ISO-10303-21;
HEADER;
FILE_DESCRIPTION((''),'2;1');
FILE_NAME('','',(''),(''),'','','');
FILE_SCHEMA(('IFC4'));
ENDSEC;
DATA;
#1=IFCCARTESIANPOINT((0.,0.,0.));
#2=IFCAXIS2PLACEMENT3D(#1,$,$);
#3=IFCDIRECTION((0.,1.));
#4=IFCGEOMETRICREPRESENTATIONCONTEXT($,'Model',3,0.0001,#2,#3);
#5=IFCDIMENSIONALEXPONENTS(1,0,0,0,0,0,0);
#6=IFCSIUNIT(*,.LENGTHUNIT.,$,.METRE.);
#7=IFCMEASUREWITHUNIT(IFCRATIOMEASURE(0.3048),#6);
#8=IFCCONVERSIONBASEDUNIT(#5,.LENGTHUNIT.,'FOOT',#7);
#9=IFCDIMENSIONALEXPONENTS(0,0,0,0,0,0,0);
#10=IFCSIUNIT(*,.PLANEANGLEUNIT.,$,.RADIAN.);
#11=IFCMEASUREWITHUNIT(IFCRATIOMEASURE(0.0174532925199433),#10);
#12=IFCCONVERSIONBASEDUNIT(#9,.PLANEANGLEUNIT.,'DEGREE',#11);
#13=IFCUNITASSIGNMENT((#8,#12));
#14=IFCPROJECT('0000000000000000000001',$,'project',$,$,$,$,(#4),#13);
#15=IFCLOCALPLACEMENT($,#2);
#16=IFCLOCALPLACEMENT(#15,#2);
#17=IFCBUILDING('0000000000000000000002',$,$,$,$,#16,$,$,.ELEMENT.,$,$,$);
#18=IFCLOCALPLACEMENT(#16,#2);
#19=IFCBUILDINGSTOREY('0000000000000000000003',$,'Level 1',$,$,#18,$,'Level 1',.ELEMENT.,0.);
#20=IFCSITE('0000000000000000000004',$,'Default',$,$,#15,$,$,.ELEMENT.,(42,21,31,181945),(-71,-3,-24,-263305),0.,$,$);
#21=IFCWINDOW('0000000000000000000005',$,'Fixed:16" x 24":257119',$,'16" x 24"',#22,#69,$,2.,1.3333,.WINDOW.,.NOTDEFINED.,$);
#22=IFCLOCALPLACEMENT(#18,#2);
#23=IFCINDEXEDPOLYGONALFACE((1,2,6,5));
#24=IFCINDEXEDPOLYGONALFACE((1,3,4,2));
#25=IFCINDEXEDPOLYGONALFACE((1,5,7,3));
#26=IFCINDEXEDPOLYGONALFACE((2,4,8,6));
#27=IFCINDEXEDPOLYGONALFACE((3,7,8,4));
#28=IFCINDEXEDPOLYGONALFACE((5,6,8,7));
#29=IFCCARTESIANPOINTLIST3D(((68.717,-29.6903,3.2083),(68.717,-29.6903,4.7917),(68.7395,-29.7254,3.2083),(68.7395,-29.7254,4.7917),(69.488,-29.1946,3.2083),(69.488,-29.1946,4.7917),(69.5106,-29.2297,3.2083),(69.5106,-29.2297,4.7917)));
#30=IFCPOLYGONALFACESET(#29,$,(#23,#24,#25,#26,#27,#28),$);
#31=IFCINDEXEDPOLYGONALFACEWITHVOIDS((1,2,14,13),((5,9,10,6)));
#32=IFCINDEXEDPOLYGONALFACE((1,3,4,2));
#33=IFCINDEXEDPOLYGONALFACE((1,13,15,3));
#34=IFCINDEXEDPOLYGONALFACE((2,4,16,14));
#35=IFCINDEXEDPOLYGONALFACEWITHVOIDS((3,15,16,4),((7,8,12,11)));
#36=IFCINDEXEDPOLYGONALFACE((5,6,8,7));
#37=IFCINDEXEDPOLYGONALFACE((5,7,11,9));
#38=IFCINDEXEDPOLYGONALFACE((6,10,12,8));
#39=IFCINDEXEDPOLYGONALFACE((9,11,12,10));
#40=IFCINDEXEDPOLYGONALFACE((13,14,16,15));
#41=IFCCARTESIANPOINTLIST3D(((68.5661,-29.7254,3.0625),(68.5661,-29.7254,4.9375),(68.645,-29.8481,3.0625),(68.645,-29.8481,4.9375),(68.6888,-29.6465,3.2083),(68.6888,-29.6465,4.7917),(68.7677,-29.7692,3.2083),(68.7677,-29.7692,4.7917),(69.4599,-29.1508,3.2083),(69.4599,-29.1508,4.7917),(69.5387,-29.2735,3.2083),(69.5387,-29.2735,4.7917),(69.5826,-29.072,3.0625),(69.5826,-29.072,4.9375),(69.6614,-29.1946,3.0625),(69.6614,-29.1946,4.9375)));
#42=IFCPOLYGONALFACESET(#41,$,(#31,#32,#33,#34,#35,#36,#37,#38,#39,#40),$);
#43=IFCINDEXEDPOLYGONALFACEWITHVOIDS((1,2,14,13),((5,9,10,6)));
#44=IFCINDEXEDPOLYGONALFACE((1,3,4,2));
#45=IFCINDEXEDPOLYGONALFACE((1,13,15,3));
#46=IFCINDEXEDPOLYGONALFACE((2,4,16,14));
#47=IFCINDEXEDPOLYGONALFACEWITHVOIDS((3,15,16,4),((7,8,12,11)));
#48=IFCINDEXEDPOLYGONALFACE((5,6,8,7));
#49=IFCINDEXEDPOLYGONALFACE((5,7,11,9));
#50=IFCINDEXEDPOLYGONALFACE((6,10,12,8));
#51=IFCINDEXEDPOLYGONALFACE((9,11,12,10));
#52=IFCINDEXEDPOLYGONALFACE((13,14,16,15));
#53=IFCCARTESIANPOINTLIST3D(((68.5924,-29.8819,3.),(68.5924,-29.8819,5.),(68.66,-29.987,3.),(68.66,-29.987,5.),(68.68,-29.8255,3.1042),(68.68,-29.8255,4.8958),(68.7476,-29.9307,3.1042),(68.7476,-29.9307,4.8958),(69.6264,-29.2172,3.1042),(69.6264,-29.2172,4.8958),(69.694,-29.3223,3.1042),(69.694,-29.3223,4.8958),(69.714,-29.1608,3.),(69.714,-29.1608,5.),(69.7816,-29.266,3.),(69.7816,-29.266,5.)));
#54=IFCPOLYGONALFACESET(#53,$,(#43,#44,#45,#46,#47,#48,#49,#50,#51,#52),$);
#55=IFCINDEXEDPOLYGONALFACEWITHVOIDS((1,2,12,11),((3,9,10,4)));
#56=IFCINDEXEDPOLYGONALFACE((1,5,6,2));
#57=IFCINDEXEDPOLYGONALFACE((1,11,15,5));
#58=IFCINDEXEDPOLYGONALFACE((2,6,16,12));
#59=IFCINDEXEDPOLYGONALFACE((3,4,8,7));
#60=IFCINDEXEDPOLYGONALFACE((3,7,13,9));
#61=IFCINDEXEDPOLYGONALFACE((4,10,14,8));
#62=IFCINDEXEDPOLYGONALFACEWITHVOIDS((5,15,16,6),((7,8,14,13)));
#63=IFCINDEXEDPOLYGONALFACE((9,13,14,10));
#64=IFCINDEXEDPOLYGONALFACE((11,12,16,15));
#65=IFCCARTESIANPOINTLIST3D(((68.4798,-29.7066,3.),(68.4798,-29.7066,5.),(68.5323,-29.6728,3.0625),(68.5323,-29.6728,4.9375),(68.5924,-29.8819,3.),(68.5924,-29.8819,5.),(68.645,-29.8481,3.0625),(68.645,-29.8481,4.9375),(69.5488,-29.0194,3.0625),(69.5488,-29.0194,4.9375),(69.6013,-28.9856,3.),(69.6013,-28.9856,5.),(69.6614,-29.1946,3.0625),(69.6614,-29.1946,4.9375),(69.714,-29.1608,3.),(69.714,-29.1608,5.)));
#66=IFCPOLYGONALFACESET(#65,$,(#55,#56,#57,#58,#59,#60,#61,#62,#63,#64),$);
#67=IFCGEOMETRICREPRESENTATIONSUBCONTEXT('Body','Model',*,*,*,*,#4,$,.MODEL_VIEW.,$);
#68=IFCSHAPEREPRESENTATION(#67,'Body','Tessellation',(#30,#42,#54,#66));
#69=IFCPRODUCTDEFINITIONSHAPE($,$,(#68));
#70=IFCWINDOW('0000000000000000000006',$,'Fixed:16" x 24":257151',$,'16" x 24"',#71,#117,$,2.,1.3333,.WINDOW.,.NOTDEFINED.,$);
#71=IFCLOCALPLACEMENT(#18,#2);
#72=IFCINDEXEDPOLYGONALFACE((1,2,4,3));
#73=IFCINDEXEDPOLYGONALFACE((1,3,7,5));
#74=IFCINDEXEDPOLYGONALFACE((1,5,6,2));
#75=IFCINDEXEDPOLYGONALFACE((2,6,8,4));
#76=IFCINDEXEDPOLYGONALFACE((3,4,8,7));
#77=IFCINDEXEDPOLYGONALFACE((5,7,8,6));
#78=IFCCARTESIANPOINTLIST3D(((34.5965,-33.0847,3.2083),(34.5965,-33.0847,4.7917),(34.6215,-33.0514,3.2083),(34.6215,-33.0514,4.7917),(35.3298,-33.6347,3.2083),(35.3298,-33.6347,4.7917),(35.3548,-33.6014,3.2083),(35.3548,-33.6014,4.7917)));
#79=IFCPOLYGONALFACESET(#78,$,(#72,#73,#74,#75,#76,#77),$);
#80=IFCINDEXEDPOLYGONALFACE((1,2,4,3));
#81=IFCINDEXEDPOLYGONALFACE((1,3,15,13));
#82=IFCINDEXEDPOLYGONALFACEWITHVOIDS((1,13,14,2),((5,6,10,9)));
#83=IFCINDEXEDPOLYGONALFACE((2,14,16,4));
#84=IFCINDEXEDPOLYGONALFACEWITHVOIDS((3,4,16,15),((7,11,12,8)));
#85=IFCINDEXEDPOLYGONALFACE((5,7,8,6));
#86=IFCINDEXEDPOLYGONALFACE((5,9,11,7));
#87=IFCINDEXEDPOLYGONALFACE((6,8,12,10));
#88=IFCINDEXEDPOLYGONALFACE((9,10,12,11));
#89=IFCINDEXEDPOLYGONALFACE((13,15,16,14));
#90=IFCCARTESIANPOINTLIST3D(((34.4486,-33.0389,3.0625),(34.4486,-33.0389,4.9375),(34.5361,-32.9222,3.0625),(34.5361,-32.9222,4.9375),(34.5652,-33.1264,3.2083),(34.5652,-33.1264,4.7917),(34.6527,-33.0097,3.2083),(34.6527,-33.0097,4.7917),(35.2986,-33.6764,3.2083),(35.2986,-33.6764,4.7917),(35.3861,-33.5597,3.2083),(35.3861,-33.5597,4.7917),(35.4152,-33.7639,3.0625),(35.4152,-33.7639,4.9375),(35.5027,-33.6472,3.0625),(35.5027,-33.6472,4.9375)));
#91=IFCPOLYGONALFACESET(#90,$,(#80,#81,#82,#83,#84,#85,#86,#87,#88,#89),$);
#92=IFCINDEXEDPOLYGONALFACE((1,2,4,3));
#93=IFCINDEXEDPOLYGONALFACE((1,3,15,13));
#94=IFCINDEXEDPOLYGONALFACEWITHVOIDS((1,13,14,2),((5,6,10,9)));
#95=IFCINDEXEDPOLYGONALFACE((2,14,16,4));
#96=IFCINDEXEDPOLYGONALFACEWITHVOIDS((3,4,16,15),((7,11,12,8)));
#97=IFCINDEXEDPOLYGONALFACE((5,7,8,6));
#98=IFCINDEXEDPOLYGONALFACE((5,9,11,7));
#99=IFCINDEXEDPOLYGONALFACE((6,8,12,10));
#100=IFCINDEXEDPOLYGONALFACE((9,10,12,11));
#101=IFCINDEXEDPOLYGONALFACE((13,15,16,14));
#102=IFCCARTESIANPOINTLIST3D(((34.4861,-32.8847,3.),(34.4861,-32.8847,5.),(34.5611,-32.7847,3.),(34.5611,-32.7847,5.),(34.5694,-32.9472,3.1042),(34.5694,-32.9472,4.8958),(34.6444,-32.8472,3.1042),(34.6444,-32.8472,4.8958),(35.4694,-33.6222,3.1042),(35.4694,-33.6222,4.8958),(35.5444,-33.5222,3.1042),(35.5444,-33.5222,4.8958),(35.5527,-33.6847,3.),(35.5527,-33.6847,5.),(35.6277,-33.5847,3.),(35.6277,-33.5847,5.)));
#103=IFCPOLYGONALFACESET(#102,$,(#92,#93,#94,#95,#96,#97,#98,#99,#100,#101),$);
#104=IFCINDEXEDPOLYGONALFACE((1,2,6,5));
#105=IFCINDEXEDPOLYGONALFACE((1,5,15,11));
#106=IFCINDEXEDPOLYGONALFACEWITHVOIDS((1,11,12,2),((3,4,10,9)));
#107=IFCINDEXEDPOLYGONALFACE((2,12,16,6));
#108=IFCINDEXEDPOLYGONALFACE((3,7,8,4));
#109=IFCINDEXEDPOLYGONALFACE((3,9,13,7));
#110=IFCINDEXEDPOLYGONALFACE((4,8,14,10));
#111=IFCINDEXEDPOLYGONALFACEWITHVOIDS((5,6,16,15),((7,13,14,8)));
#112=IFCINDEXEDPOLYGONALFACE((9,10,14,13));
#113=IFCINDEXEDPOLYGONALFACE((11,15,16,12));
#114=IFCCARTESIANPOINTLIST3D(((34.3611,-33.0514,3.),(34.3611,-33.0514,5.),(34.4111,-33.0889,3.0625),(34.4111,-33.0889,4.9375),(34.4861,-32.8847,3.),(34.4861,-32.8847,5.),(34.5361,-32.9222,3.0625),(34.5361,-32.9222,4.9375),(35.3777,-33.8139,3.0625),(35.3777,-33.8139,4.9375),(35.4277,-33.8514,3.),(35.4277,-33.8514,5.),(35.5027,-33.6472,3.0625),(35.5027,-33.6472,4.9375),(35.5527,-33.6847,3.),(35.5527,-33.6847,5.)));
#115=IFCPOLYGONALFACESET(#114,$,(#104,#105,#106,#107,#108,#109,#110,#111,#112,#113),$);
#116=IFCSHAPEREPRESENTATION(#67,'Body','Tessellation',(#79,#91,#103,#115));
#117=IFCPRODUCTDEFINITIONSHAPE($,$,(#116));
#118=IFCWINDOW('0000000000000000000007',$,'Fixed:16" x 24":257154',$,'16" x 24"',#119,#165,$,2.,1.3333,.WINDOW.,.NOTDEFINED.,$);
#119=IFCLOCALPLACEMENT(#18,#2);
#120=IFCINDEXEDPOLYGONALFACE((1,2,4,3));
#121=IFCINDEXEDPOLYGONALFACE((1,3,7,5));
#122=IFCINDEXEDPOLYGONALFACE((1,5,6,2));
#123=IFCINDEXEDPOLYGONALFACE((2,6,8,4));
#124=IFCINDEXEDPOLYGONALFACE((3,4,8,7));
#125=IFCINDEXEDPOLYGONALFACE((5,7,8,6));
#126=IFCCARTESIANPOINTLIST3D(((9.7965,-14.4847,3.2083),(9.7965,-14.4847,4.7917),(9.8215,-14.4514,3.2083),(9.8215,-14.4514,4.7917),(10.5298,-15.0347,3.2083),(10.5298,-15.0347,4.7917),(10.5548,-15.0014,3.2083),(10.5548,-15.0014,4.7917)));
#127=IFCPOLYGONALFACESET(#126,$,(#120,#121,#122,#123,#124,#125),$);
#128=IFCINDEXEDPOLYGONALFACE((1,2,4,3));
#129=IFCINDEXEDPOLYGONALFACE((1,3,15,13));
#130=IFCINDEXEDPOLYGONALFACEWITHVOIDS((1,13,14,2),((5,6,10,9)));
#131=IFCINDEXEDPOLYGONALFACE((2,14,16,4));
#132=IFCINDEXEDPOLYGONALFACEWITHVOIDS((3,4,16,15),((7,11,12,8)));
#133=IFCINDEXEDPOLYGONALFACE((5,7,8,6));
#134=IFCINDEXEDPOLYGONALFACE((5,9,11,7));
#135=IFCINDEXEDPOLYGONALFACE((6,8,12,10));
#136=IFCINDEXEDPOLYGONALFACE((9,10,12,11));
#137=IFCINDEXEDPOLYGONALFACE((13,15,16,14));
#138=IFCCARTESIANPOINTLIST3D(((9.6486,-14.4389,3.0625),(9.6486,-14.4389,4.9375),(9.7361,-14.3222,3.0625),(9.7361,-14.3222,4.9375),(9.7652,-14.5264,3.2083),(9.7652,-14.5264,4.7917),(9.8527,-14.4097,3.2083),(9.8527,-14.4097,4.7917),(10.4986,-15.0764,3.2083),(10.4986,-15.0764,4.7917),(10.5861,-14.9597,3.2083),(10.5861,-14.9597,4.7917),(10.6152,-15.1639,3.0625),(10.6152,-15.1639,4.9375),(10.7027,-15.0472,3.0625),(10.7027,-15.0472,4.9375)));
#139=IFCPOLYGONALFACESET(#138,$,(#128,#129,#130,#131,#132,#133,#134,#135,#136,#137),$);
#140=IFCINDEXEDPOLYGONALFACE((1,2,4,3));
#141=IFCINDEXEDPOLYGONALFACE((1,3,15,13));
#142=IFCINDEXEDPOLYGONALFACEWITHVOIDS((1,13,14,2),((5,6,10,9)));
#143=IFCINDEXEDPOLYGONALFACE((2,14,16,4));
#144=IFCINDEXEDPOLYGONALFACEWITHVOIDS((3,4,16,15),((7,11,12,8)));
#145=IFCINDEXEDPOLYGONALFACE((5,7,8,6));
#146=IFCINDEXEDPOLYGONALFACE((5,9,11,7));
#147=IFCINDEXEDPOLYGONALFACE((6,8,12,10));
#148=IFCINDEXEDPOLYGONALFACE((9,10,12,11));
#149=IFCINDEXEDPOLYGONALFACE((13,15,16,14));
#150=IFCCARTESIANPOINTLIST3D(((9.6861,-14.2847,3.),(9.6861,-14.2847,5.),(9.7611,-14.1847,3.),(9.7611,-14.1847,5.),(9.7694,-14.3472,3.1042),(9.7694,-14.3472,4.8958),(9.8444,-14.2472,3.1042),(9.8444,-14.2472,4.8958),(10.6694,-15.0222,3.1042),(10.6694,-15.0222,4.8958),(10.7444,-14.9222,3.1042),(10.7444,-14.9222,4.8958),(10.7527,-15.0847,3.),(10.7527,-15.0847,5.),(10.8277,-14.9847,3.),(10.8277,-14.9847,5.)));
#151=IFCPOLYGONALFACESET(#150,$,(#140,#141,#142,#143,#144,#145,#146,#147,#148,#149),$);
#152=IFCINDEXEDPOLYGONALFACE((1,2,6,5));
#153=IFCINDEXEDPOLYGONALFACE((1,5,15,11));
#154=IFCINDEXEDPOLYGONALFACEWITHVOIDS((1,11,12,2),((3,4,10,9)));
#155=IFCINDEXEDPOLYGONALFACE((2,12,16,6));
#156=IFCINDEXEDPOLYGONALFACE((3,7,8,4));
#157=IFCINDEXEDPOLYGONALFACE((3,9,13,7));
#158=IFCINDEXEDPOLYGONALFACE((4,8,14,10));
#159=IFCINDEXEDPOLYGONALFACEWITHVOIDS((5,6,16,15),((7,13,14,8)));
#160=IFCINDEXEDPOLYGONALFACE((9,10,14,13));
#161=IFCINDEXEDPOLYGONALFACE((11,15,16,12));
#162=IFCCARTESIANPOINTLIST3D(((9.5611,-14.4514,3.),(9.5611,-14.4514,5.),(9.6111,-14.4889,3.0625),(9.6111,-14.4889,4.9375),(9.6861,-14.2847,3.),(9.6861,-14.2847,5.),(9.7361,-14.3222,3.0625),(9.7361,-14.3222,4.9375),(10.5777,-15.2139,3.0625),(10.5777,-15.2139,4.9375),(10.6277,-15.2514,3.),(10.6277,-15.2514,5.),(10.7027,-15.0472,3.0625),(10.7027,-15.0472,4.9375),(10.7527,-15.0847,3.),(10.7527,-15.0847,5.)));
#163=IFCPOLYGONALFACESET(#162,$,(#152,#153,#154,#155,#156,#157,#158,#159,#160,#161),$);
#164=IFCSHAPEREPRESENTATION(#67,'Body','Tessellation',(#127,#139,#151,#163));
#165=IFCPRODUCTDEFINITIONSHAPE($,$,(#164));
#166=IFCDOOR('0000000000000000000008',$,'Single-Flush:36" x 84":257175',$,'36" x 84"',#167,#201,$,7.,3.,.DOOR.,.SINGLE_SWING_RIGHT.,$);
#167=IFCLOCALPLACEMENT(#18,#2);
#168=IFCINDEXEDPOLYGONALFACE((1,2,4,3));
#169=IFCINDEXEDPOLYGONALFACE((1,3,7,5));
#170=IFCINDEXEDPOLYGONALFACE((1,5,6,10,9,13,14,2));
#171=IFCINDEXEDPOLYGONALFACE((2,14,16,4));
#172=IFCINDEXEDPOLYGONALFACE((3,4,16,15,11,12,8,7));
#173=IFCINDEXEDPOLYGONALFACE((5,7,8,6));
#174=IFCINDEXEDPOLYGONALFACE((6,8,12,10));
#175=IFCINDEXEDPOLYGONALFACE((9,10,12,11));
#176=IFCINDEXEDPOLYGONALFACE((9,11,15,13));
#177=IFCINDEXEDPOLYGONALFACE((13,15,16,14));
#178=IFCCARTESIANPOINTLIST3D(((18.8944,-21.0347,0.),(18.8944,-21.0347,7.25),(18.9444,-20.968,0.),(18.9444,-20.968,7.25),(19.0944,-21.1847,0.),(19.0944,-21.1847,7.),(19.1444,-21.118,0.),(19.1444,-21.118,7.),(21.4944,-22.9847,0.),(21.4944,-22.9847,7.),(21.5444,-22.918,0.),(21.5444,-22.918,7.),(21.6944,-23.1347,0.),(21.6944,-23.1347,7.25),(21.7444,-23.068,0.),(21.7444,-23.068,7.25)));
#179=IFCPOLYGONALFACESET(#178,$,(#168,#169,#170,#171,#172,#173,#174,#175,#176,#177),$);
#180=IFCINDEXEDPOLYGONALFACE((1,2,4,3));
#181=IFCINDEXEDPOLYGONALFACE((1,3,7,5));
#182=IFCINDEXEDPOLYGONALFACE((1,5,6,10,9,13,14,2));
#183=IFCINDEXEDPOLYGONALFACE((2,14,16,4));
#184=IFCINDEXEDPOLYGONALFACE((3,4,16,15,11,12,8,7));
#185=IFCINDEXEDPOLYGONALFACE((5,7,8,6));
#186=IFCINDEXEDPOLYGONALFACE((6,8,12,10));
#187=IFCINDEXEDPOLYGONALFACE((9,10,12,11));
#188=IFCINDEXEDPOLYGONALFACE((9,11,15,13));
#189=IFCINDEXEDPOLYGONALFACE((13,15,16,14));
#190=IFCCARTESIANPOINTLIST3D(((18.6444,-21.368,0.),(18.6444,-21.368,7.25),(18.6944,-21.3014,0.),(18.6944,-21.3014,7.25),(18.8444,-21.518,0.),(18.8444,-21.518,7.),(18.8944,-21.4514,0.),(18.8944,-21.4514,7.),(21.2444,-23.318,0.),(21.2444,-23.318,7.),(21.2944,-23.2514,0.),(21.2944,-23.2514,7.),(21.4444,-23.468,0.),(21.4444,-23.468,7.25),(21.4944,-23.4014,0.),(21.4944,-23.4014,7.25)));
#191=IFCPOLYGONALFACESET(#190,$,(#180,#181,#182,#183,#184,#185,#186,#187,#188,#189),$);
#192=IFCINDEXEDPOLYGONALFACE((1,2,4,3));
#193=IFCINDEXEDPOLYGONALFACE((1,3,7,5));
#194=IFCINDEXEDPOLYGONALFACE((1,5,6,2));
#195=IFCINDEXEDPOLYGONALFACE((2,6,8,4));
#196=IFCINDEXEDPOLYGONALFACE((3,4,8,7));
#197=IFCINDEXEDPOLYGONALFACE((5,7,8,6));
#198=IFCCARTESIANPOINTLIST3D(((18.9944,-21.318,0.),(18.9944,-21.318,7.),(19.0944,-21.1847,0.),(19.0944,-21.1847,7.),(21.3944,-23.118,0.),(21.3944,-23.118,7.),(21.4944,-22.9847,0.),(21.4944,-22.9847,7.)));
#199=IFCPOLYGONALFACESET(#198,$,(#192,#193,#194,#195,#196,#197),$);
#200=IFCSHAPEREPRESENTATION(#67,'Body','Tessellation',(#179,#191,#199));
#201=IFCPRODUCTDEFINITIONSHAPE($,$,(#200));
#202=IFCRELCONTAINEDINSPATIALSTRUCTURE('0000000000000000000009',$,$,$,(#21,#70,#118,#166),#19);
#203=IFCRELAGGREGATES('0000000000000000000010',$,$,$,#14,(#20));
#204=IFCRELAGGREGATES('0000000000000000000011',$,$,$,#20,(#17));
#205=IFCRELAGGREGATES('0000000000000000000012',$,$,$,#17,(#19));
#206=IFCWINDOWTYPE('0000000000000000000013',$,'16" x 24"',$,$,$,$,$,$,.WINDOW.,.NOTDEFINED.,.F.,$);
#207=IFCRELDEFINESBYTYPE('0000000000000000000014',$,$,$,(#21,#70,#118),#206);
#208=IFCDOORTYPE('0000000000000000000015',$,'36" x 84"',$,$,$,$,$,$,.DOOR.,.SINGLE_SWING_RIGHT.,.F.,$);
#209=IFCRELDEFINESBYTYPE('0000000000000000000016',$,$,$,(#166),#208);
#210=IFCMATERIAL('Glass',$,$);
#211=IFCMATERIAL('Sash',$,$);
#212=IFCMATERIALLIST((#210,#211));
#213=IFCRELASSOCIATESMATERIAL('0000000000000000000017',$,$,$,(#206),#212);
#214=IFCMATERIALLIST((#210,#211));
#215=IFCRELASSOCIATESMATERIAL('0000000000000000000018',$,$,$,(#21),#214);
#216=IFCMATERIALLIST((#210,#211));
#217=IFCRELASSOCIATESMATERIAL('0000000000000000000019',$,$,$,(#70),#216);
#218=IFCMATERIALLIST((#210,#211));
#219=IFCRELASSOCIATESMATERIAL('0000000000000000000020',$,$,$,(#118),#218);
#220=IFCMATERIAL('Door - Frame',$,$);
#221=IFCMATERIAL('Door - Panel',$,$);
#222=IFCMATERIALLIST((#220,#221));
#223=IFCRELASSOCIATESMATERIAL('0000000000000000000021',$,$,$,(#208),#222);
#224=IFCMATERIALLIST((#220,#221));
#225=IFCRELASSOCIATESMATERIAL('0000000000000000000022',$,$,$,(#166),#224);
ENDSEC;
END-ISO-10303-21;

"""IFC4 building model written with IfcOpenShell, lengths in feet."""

from ifc_helpers import new_model, entity, si_unit, converted_unit, direction, frame, frame_2d, origin, origin_2d_with_axis, place, context, subcontext, project, spatial, polyline, rectangle, outline, extrude, source, transform, mapped, material, material_list, type_object, type_shapes, element, save


model = new_model("IFC4")

# Units and contexts
model_context = context("Model", 3, precision=0.0001, world=origin(), true_north=direction((0.0, 1.0)))
body_context = subcontext(model_context, "Body", "Model", "MODEL_VIEW")
ifc_project = project(units=[converted_unit("LENGTHUNIT", "FOOT", entity("IfcRatioMeasure", 0.3048), si_unit("LENGTHUNIT", "METRE"), dimensions=[1, 0, 0, 0, 0, 0, 0]), converted_unit("PLANEANGLEUNIT", "DEGREE", entity("IfcRatioMeasure", 0.0174532925199433), si_unit("PLANEANGLEUNIT", "RADIAN"), dimensions=[0, 0, 0, 0, 0, 0, 0])], contexts=[model_context])

# Site, building, storey
site_placement = place(None, origin())
site = spatial("IfcSite", under=ifc_project, at=site_placement, Name="Default", CompositionType="ELEMENT", RefLatitude=(42, 21, 31, 181945), RefLongitude=(-71, -3, -24, -263305), RefElevation=0.0)
building_placement = place(site_placement, origin())
building = spatial("IfcBuilding", under=site, at=building_placement, CompositionType="ELEMENT")
storey_placement = place(building_placement, origin())
storey = spatial("IfcBuildingStorey", under=building, at=storey_placement, Name="Level 1", LongName="Level 1", CompositionType="ELEMENT", Elevation=0.0)

# Windows
ifc_material_1 = material(Name="Glass")
ifc_material_2 = material(Name="Sash")
ifc_material_list_1 = material_list([ifc_material_1, ifc_material_2])
window_type = type_object("IfcWindowType", Name="16\" x 24\"", ParameterTakesPrecedence=False, PartitioningType="NOTDEFINED", PredefinedType="WINDOW", material=ifc_material_list_1)
shared_shape_1 = source(origin(), body_context, "Body", "SweptSolid", [
    extrude(rectangle(XDim=0.0417, YDim=0.9167, at=origin_2d_with_axis()), frame((0.6667, 0.1979, 0.2083), z_axis=(0.0, 0.0, 1.0), x_axis=(0.0, 1.0, 0.0)), (0.0, 0.0, 1.0), 1.5833),
    extrude(outline(polyline([(-0.6042, -0.9375), (0.6042, -0.9375), (0.6042, 0.9375), (-0.6042, 0.9375), (-0.6042, -0.9375)]), holes=[polyline([(-0.4583, -0.7917), (-0.4583, 0.7917), (0.4583, 0.7917), (0.4583, -0.7917), (-0.4583, -0.7917)])]), frame((0.6667, 0.125, 1.0), z_axis=(0.0, 1.0, 0.0), x_axis=(1.0, 0.0, 0.0)), (0.0, 0.0, 1.0), 0.1458),
    extrude(outline(polyline([(-0.6667, -1.0), (0.6667, -1.0), (0.6667, 1.0), (-0.6667, 1.0), (-0.6667, -1.0)]), holes=[polyline([(-0.5625, -0.8958), (-0.5625, 0.8958), (0.5625, 0.8958), (0.5625, -0.8958), (-0.5625, -0.8958)])]), frame((0.6667, 0.0, 1.0), z_axis=(0.0, 1.0, 0.0), x_axis=(1.0, 0.0, 0.0)), (0.0, 0.0, 1.0), 0.125),
    extrude(outline(polyline([(-1.0, -0.6667), (1.0, -0.6667), (1.0, 0.6667), (-1.0, 0.6667), (-1.0, -0.6667)]), holes=[polyline([(-0.9375, -0.6042), (-0.9375, 0.6042), (0.9375, 0.6042), (0.9375, -0.6042), (-0.9375, -0.6042)])]), frame((0.6667, 0.125, 1.0), z_axis=(0.0, 1.0, 0.0), x_axis=(0.0, 0.0, -1.0)), (0.0, 0.0, 1.0), 0.2083),
])
type_shapes(window_type, [shared_shape_1])
placement_1 = place(storey_placement, frame((103.9574, -7.0977, 0.0), z_axis=(0.0, 0.0, 1.0), x_axis=(-0.841178, -0.540758, 0.0)))
ifc_material_list_2 = material_list([ifc_material_1, ifc_material_2])
placement_2 = place(placement_1, frame((42.069, 0.1667, 3.0)))
window_1_placement = place(placement_2, frame((0.0, 0.0, 0.0), z_axis=(0.0, 0.0, 1.0), x_axis=(-1.0, 0.0, 0.0)))
element("IfcWindow", 1, at=window_1_placement, inside=storey, type_object=window_type, material=ifc_material_list_2, Name="Fixed:16\" x 24\":257119", ObjectType="16\" x 24\"", OverallHeight=2.0, OverallWidth=1.3333, PartitioningType="NOTDEFINED", PredefinedType="WINDOW", context=body_context, shape_type="MappedRepresentation", body=[
    mapped(shared_shape_1, transform((0.0, 0.0, 0.0), scale=1.0)),
])
ifc_material_list_3 = material_list([ifc_material_1, ifc_material_2])
placement_3 = place(storey_placement, frame((47.9059, -43.0017, 0.0), z_axis=(0.0, 0.0, 1.0), x_axis=(-0.8, 0.6, 0.0)))
placement_4 = place(placement_3, frame((15.4728, -0.1667, 3.0)))
window_2_placement = place(placement_4, origin())
element("IfcWindow", 2, at=window_2_placement, inside=storey, type_object=window_type, material=ifc_material_list_3, Name="Fixed:16\" x 24\":257151", ObjectType="16\" x 24\"", OverallHeight=2.0, OverallWidth=1.3333, PartitioningType="NOTDEFINED", PredefinedType="WINDOW", context=body_context, shape_type="MappedRepresentation", body=[
    mapped(shared_shape_1, transform((0.0, 0.0, 0.0), scale=1.0)),
])
ifc_material_list_4 = material_list([ifc_material_1, ifc_material_2])
placement_5 = place(placement_3, frame((46.4728, -0.1667, 3.0)))
window_3_placement = place(placement_5, origin())
element("IfcWindow", 3, at=window_3_placement, inside=storey, type_object=window_type, material=ifc_material_list_4, Name="Fixed:16\" x 24\":257154", ObjectType="16\" x 24\"", OverallHeight=2.0, OverallWidth=1.3333, PartitioningType="NOTDEFINED", PredefinedType="WINDOW", context=body_context, shape_type="MappedRepresentation", body=[
    mapped(shared_shape_1, transform((0.0, 0.0, 0.0), scale=1.0)),
])

# Door
ifc_material_3 = material(Name="Door - Frame")
ifc_material_4 = material(Name="Door - Panel")
ifc_material_list_5 = material_list([ifc_material_3, ifc_material_4])
ifc_material_list_6 = material_list([ifc_material_3, ifc_material_4])
door_type = type_object("IfcDoorType", Name="36\" x 84\"", OperationType="SINGLE_SWING_RIGHT", ParameterTakesPrecedence=False, PredefinedType="DOOR", material=ifc_material_list_6)
shared_shape_2 = source(origin(), body_context, "Body", "SweptSolid", [
    extrude(outline(polyline([(-1.75, -3.6875), (1.75, -3.6875), (1.75, 3.5625), (1.5, 3.5625), (1.5, -3.4375), (-1.5, -3.4375), (-1.5, 3.5625), (-1.75, 3.5625), (-1.75, -3.6875)])), frame((1.5, 0.3333, 3.5625), z_axis=(0.0, 1.0, 0.0), x_axis=(1.0, 0.0, 0.0)), (0.0, 0.0, 1.0), 0.0833),
    extrude(outline(polyline([(-3.6875, -1.75), (3.5625, -1.75), (3.5625, -1.5), (-3.4375, -1.5), (-3.4375, 1.5), (3.5625, 1.5), (3.5625, 1.75), (-3.6875, 1.75), (-3.6875, -1.75)])), frame((1.5, -0.0833, 3.5625), z_axis=(0.0, 1.0, 0.0), x_axis=(0.0, 0.0, -1.0)), (0.0, 0.0, 1.0), 0.0833),
    extrude(rectangle(XDim=0.1667, YDim=3.0, at=frame_2d((0.0, 0.0), x_axis=(1.0, 0.0))), frame((1.5, 0.25, 0.0), z_axis=(0.0, 0.0, 1.0), x_axis=(0.0, 1.0, 0.0)), (0.0, 0.0, 1.0), 7.0),
])
type_shapes(door_type, [shared_shape_2])
placement_6 = place(placement_3, frame((36.1394, 0.1667, 0.0)))
door_1_placement = place(placement_6, frame((0.0, 0.0, 0.0), z_axis=(0.0, 0.0, 1.0), x_axis=(-1.0, 0.0, 0.0)))
element("IfcDoor", 4, at=door_1_placement, inside=storey, type_object=door_type, material=ifc_material_list_5, Name="Single-Flush:36\" x 84\":257175", ObjectType="36\" x 84\"", OperationType="SINGLE_SWING_RIGHT", OverallHeight=7.0, OverallWidth=3.0, PredefinedType="DOOR", context=body_context, shape_type="MappedRepresentation", body=[
    mapped(shared_shape_2, transform((0.0, 0.0, 0.0), scale=1.0)),
])

save(model, "model.ifc")
